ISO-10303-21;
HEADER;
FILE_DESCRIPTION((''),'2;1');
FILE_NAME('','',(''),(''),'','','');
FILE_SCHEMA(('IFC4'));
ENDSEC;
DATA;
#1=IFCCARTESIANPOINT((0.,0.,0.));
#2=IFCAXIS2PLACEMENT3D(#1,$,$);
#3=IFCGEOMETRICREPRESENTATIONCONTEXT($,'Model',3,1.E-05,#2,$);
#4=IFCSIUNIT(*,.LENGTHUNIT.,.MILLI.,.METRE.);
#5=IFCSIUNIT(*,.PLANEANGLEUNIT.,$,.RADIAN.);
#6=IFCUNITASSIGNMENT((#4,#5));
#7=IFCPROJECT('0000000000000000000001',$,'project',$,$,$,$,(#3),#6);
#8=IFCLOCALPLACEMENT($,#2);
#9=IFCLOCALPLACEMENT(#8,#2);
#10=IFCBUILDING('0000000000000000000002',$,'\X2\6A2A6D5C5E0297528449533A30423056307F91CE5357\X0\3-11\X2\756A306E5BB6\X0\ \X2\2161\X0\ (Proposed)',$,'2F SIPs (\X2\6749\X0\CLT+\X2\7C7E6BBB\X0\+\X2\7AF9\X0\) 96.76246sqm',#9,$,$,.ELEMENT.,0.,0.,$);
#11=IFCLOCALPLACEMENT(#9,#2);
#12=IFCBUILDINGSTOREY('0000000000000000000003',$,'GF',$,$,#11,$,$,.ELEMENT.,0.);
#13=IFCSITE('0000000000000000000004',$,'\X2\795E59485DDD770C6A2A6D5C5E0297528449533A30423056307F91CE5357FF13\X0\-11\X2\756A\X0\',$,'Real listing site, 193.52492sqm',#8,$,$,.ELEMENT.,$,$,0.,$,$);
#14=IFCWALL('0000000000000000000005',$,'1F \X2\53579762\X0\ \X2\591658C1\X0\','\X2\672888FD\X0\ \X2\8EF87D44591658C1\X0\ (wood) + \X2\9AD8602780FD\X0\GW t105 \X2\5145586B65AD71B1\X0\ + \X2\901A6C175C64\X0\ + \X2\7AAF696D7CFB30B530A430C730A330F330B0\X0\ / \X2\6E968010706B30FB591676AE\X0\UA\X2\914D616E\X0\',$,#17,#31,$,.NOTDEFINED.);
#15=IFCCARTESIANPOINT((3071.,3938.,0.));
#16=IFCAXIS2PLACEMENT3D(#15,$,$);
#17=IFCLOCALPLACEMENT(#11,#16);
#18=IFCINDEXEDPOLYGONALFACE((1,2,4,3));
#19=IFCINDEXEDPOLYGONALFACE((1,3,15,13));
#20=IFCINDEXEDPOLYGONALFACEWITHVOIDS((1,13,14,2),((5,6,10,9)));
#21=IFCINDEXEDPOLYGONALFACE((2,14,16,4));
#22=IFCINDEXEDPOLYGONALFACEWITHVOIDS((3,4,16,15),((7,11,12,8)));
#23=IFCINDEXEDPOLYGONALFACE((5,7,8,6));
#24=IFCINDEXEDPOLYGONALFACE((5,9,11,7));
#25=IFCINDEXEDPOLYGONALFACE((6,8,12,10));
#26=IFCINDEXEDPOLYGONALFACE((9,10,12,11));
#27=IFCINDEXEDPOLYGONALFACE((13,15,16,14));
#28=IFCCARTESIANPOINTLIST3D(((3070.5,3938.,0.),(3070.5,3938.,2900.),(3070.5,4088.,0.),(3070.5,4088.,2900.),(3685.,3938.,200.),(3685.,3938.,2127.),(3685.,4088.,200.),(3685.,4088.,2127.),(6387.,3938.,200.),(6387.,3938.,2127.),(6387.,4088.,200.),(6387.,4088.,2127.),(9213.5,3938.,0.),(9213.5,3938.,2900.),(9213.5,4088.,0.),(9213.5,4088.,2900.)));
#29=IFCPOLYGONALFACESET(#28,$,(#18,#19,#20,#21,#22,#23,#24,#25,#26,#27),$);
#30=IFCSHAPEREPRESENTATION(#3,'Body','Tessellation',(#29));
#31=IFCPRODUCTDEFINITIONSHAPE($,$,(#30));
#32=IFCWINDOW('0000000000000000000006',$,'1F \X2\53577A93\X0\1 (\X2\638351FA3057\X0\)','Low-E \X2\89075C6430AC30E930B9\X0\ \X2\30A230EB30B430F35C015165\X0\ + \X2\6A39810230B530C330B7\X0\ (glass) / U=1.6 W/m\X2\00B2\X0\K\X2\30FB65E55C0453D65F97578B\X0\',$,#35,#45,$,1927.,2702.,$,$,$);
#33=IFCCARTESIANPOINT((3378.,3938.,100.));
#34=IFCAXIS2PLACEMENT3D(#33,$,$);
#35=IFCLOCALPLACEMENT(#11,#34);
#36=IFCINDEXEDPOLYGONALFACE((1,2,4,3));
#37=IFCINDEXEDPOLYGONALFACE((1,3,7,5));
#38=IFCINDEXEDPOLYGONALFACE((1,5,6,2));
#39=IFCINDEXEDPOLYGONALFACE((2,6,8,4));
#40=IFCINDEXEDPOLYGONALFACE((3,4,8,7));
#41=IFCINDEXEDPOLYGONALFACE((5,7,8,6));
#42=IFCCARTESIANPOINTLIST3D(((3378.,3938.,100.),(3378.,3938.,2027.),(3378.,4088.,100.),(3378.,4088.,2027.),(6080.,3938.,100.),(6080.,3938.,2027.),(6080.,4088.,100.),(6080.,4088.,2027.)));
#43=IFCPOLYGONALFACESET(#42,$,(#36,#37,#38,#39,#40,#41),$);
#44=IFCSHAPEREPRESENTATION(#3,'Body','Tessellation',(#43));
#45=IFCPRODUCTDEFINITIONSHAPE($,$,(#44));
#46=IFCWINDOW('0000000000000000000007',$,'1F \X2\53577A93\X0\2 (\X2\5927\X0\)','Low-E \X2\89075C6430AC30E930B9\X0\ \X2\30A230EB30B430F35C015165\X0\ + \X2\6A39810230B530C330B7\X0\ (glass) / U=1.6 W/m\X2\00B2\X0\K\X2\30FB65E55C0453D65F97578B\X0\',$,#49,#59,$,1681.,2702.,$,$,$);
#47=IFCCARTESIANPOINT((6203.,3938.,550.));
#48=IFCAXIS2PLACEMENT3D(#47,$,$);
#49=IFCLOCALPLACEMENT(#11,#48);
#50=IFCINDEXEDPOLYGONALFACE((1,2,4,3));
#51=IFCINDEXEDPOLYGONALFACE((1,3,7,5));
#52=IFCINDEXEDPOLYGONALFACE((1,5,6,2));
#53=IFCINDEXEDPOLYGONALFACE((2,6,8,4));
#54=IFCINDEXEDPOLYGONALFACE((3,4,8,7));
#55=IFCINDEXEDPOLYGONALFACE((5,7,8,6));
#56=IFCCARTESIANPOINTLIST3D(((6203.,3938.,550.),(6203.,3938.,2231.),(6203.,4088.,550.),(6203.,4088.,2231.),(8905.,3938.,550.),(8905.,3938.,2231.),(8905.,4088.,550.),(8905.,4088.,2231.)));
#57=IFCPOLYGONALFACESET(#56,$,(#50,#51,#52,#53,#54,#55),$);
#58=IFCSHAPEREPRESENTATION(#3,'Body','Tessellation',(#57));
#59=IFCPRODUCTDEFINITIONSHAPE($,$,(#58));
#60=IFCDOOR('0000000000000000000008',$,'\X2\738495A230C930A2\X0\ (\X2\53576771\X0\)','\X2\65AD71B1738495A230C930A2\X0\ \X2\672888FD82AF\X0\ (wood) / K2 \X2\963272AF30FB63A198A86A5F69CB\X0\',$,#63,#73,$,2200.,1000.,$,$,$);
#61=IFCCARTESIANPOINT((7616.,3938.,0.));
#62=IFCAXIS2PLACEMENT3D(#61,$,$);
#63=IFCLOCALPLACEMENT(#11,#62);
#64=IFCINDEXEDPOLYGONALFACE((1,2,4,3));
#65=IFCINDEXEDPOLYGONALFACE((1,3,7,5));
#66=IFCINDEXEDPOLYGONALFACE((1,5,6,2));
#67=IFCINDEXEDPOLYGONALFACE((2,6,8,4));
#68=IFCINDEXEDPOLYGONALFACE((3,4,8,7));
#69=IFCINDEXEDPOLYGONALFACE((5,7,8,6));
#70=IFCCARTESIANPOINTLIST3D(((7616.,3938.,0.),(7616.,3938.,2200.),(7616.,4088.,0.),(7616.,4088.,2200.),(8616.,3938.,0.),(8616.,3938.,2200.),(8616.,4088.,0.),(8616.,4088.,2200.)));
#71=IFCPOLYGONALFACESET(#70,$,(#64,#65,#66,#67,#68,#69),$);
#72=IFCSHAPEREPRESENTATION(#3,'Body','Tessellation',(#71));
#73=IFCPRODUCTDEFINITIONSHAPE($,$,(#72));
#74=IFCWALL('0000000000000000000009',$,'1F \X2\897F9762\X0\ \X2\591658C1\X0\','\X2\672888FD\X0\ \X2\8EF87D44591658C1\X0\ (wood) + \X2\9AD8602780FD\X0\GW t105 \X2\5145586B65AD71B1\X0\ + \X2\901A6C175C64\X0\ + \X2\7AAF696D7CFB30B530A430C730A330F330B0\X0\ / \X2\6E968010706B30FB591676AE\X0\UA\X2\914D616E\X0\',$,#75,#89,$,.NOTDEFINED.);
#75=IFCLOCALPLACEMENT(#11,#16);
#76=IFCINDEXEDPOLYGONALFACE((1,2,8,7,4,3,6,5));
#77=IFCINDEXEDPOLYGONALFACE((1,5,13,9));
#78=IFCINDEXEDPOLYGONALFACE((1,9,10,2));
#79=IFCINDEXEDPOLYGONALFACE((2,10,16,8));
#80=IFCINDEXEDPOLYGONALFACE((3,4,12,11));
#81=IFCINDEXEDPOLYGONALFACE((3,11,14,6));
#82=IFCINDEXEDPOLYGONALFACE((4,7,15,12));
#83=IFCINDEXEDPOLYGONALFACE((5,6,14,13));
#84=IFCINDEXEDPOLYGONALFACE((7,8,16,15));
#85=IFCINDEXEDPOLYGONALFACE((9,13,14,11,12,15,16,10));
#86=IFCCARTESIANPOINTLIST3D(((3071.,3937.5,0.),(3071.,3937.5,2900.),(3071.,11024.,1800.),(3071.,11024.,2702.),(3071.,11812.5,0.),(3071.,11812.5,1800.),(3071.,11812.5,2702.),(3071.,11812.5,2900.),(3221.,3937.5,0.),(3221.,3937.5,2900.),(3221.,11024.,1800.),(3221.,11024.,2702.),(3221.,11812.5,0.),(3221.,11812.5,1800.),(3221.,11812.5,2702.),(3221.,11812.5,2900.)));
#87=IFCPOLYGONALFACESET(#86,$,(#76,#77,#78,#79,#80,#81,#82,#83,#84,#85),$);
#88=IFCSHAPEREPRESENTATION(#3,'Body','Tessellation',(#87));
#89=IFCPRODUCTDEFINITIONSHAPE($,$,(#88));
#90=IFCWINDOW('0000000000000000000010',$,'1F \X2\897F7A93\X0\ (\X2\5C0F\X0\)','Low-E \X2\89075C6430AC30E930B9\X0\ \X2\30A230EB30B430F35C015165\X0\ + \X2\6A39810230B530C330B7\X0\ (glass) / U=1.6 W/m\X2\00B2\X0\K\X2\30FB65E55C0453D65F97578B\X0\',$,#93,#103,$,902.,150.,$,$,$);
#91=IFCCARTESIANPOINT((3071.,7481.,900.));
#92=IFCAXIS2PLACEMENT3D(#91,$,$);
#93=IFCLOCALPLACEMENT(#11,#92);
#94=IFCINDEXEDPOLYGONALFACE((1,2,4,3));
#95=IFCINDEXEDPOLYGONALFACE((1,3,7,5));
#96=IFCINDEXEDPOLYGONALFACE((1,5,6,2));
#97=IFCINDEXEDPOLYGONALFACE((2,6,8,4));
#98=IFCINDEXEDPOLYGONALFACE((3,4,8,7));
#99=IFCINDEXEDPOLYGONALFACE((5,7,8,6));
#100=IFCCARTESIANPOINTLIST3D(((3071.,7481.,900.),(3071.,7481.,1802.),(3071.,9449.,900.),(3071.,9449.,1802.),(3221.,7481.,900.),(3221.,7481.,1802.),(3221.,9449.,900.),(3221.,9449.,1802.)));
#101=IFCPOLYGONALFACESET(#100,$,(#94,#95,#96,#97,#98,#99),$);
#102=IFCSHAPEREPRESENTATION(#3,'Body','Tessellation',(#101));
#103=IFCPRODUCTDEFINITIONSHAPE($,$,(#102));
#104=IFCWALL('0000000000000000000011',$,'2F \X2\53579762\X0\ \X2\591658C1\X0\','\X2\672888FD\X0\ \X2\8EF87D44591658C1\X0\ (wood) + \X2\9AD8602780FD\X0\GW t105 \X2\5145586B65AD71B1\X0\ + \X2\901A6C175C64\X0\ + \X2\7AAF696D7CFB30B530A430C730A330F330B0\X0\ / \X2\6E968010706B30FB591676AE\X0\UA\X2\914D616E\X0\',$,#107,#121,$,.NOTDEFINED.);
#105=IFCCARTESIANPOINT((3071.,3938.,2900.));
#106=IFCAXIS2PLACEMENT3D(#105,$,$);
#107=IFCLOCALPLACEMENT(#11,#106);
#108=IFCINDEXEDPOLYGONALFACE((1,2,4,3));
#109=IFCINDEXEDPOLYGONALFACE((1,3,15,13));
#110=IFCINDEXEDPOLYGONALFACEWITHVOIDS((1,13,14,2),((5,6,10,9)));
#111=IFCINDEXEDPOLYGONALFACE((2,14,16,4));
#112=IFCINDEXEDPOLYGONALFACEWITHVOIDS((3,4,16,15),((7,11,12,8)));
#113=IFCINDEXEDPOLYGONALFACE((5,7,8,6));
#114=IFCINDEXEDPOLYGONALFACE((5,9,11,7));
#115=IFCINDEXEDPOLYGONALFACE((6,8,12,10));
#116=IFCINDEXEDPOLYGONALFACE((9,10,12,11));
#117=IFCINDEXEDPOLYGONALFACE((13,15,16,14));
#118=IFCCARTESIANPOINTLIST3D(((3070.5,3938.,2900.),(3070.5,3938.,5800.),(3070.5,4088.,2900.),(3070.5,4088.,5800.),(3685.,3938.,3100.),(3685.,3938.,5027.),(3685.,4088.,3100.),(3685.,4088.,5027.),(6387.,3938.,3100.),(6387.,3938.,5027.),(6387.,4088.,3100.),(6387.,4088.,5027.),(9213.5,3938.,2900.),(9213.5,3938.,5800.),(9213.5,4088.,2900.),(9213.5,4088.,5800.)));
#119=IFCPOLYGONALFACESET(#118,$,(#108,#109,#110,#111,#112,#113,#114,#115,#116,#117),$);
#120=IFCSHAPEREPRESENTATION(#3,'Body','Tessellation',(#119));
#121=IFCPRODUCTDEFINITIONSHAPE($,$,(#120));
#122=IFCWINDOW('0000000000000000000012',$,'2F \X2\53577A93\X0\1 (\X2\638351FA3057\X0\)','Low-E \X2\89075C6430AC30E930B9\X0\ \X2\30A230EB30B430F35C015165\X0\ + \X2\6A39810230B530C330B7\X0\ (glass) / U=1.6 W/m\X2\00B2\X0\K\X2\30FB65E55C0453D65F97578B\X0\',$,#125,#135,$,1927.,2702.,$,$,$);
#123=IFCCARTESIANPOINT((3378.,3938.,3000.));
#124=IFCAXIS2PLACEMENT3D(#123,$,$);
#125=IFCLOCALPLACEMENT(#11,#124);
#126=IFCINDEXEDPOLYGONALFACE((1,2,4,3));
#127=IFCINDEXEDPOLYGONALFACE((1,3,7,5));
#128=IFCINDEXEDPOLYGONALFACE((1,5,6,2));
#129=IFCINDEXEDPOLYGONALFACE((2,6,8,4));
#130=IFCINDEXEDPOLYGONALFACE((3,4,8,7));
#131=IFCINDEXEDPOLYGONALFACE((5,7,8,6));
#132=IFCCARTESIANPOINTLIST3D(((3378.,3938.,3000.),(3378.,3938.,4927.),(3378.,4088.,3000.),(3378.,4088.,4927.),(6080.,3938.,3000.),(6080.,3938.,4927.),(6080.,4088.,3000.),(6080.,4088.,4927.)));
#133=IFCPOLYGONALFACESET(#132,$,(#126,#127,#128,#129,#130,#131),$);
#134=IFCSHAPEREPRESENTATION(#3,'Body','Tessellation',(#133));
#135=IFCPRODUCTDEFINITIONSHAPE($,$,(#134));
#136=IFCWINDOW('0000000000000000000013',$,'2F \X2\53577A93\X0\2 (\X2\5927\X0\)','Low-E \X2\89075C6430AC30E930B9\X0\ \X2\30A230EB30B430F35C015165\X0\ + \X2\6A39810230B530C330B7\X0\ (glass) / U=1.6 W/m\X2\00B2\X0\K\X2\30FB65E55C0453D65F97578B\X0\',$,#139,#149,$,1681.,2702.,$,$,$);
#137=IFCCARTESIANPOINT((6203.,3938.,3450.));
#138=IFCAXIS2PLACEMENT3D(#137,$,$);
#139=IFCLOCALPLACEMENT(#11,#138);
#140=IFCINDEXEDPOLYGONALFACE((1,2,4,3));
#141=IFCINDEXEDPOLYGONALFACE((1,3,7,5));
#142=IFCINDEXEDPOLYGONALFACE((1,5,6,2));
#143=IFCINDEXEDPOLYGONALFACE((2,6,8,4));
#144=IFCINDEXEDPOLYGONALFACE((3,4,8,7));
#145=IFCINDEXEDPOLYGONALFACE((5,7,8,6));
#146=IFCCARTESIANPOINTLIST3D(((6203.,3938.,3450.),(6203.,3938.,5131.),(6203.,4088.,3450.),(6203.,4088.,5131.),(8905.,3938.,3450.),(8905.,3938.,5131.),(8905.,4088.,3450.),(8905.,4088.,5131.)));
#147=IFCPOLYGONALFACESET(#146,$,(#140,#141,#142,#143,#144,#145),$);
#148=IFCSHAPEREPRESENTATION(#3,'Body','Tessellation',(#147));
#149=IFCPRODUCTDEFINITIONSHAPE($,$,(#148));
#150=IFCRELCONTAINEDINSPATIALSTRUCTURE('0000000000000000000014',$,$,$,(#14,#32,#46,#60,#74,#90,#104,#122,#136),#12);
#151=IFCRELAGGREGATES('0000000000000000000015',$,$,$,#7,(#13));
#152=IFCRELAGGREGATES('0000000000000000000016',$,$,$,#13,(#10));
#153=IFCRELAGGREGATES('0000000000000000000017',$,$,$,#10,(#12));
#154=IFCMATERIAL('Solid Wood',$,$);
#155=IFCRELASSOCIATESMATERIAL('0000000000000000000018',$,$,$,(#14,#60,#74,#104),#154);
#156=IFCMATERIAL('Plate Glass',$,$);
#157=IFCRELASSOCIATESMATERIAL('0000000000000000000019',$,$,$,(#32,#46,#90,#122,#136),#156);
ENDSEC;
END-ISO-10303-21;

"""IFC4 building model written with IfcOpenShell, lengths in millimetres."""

from ifc_helpers import new_model, si_unit, frame, frame_2d, origin, place, context, project, spatial, rectangle, extrude, material, element, fill, save


model = new_model("IFC4")

# Units and contexts
model_context = context("Model", 3, precision=1e-05, world=origin())
ifc_project = project(units=[si_unit("LENGTHUNIT", "METRE", prefix="MILLI"), si_unit("PLANEANGLEUNIT", "RADIAN")], contexts=[model_context])

# Site, building, storey
site_placement = place(None, origin())
site = spatial("IfcSite", under=ifc_project, at=site_placement, Name="神奈川県横浜市青葉区あざみ野南３-11番", ObjectType="Real listing site, 193.52492sqm", CompositionType="ELEMENT", RefElevation=0.0)
building_placement = place(site_placement, origin())
building = spatial("IfcBuilding", under=site, at=building_placement, Name="横浜市青葉区あざみ野南3-11番の家 Ⅱ (Proposed)", ObjectType="2F SIPs (杉CLT+籾殻+竹) 96.76246sqm", CompositionType="ELEMENT", ElevationOfRefHeight=0.0, ElevationOfTerrain=0.0)
storey_placement = place(building_placement, origin())
storey = spatial("IfcBuildingStorey", under=building, at=storey_placement, Name="GF", CompositionType="ELEMENT", Elevation=0.0)

# Shared definitions
ifc_material_1 = material(Name="Solid Wood")

# Wall, openings, windows, door
wall_1_placement = place(storey_placement, frame((3071.0, 3938.0, 0.0)))
wall_1 = element("IfcWall", 1, at=wall_1_placement, inside=storey, material=ifc_material_1, Name="1F 南面 外壁", Description="木製 軸組外壁 (wood) + 高性能GW t105 充填断熱 + 通気層 + 窯業系サイディング / 準耐火・外皮UA配慮", PredefinedType="NOTDEFINED", context=model_context, shape_type="SweptSolid", body=[
    extrude(rectangle(XDim=6143.0, YDim=150.0, at=frame_2d((3071.0, 75.0))), frame((3071.0, 3938.0, 0.0)), (0.0, 0.0, 1.0), 2900.0),
])
opening_1_placement = place(storey_placement, frame((3378.0, 3938.0, 100.0)))
opening_1 = element("IfcOpeningElement", 2, at=opening_1_placement, cuts=wall_1, PredefinedType="NOTDEFINED", context=model_context, shape_type="SweptSolid", body=[
    extrude(rectangle(XDim=2702.0, YDim=150.0, at=frame_2d((1351.0, 75.0))), frame((3378.0, 3938.0, 100.0)), (0.0, 0.0, 1.0), 1927.0),
])
opening_2_placement = place(storey_placement, frame((6203.0, 3938.0, 550.0)))
opening_2 = element("IfcOpeningElement", 3, at=opening_2_placement, cuts=wall_1, PredefinedType="NOTDEFINED", context=model_context, shape_type="SweptSolid", body=[
    extrude(rectangle(XDim=2702.0, YDim=150.0, at=frame_2d((1351.0, 75.0))), frame((6203.0, 3938.0, 550.0)), (0.0, 0.0, 1.0), 1681.0),
])
opening_3_placement = place(storey_placement, frame((7616.0, 3938.0, 0.0)))
opening_3 = element("IfcOpeningElement", 4, at=opening_3_placement, cuts=wall_1, PredefinedType="NOTDEFINED", context=model_context, shape_type="SweptSolid", body=[
    extrude(rectangle(XDim=1000.0, YDim=150.0, at=frame_2d((500.0, 75.0))), frame((7616.0, 3938.0, 0.0)), (0.0, 0.0, 1.0), 2200.0),
])
ifc_material_2 = material(Name="Plate Glass")
window_1_placement = place(storey_placement, frame((3378.0, 3938.0, 100.0)))
window_1 = element("IfcWindow", 5, at=window_1_placement, inside=storey, material=ifc_material_2, Name="1F 南窓1 (掃出し)", Description="Low-E 複層ガラス アルゴン封入 + 樹脂サッシ (glass) / U=1.6 W/m²K・日射取得型", OverallHeight=1927.0, OverallWidth=2702.0, context=model_context, shape_type="SweptSolid", body=[
    extrude(rectangle(XDim=2702.0, YDim=150.0, at=frame_2d((1351.0, 75.0))), frame((3378.0, 3938.0, 100.0)), (0.0, 0.0, 1.0), 1927.0),
])
fill(opening_1, window_1)
window_2_placement = place(storey_placement, frame((6203.0, 3938.0, 550.0)))
window_2 = element("IfcWindow", 6, at=window_2_placement, inside=storey, material=ifc_material_2, Name="1F 南窓2 (大)", Description="Low-E 複層ガラス アルゴン封入 + 樹脂サッシ (glass) / U=1.6 W/m²K・日射取得型", OverallHeight=1681.0, OverallWidth=2702.0, context=model_context, shape_type="SweptSolid", body=[
    extrude(rectangle(XDim=2702.0, YDim=150.0, at=frame_2d((1351.0, 75.0))), frame((6203.0, 3938.0, 550.0)), (0.0, 0.0, 1.0), 1681.0),
])
fill(opening_2, window_2)
door_placement = place(storey_placement, frame((7616.0, 3938.0, 0.0)))
door = element("IfcDoor", 7, at=door_placement, inside=storey, material=ifc_material_1, Name="玄関ドア (南東)", Description="断熱玄関ドア 木製芯 (wood) / K2 防犯・採風機構", OverallHeight=2200.0, OverallWidth=1000.0, context=model_context, shape_type="SweptSolid", body=[
    extrude(rectangle(XDim=1000.0, YDim=150.0, at=frame_2d((500.0, 75.0))), frame((7616.0, 3938.0, 0.0)), (0.0, 0.0, 1.0), 2200.0),
])
fill(opening_3, door)

# Wall, opening, window
wall_2_placement = place(storey_placement, frame((3071.0, 3938.0, 0.0)))
wall_2 = element("IfcWall", 8, at=wall_2_placement, inside=storey, material=ifc_material_1, Name="1F 西面 外壁", Description="木製 軸組外壁 (wood) + 高性能GW t105 充填断熱 + 通気層 + 窯業系サイディング / 準耐火・外皮UA配慮", PredefinedType="NOTDEFINED", context=model_context, shape_type="SweptSolid", body=[
    extrude(rectangle(XDim=150.0, YDim=7875.0, at=frame_2d((75.0, 3937.0))), frame((3071.0, 3938.0, 0.0)), (0.0, 0.0, 1.0), 2900.0),
])
opening_4_placement = place(storey_placement, frame((3071.0, 7481.0, 900.0)))
opening_4 = element("IfcOpeningElement", 9, at=opening_4_placement, cuts=wall_2, PredefinedType="NOTDEFINED", context=model_context, shape_type="SweptSolid", body=[
    extrude(rectangle(XDim=150.0, YDim=1968.0, at=frame_2d((75.0, 984.0))), frame((3071.0, 7481.0, 900.0)), (0.0, 0.0, 1.0), 902.0),
])
window_3_placement = place(storey_placement, frame((3071.0, 7481.0, 900.0)))
window_3 = element("IfcWindow", 10, at=window_3_placement, inside=storey, material=ifc_material_2, Name="1F 西窓 (小)", Description="Low-E 複層ガラス アルゴン封入 + 樹脂サッシ (glass) / U=1.6 W/m²K・日射取得型", OverallHeight=902.0, OverallWidth=150.0, context=model_context, shape_type="SweptSolid", body=[
    extrude(rectangle(XDim=150.0, YDim=1968.0, at=frame_2d((75.0, 984.0))), frame((3071.0, 7481.0, 900.0)), (0.0, 0.0, 1.0), 902.0),
])
fill(opening_4, window_3)

# Wall, openings, windows
wall_3_placement = place(storey_placement, frame((3071.0, 3938.0, 2900.0)))
wall_3 = element("IfcWall", 11, at=wall_3_placement, inside=storey, material=ifc_material_1, Name="2F 南面 外壁", Description="木製 軸組外壁 (wood) + 高性能GW t105 充填断熱 + 通気層 + 窯業系サイディング / 準耐火・外皮UA配慮", PredefinedType="NOTDEFINED", context=model_context, shape_type="SweptSolid", body=[
    extrude(rectangle(XDim=6143.0, YDim=150.0, at=frame_2d((3071.0, 75.0))), frame((3071.0, 3938.0, 2900.0)), (0.0, 0.0, 1.0), 2900.0),
])
opening_5_placement = place(storey_placement, frame((3378.0, 3938.0, 3000.0)))
opening_5 = element("IfcOpeningElement", 12, at=opening_5_placement, cuts=wall_3, PredefinedType="NOTDEFINED", context=model_context, shape_type="SweptSolid", body=[
    extrude(rectangle(XDim=2702.0, YDim=150.0, at=frame_2d((1351.0, 75.0))), frame((3378.0, 3938.0, 3000.0)), (0.0, 0.0, 1.0), 1927.0),
])
opening_6_placement = place(storey_placement, frame((6203.0, 3938.0, 3450.0)))
opening_6 = element("IfcOpeningElement", 13, at=opening_6_placement, cuts=wall_3, PredefinedType="NOTDEFINED", context=model_context, shape_type="SweptSolid", body=[
    extrude(rectangle(XDim=2702.0, YDim=150.0, at=frame_2d((1351.0, 75.0))), frame((6203.0, 3938.0, 3450.0)), (0.0, 0.0, 1.0), 1681.0),
])
window_4_placement = place(storey_placement, frame((3378.0, 3938.0, 3000.0)))
window_4 = element("IfcWindow", 14, at=window_4_placement, inside=storey, material=ifc_material_2, Name="2F 南窓1 (掃出し)", Description="Low-E 複層ガラス アルゴン封入 + 樹脂サッシ (glass) / U=1.6 W/m²K・日射取得型", OverallHeight=1927.0, OverallWidth=2702.0, context=model_context, shape_type="SweptSolid", body=[
    extrude(rectangle(XDim=2702.0, YDim=150.0, at=frame_2d((1351.0, 75.0))), frame((3378.0, 3938.0, 3000.0)), (0.0, 0.0, 1.0), 1927.0),
])
fill(opening_5, window_4)
window_5_placement = place(storey_placement, frame((6203.0, 3938.0, 3450.0)))
window_5 = element("IfcWindow", 15, at=window_5_placement, inside=storey, material=ifc_material_2, Name="2F 南窓2 (大)", Description="Low-E 複層ガラス アルゴン封入 + 樹脂サッシ (glass) / U=1.6 W/m²K・日射取得型", OverallHeight=1681.0, OverallWidth=2702.0, context=model_context, shape_type="SweptSolid", body=[
    extrude(rectangle(XDim=2702.0, YDim=150.0, at=frame_2d((1351.0, 75.0))), frame((6203.0, 3938.0, 3450.0)), (0.0, 0.0, 1.0), 1681.0),
])
fill(opening_6, window_5)

save(model, "model.ifc")
